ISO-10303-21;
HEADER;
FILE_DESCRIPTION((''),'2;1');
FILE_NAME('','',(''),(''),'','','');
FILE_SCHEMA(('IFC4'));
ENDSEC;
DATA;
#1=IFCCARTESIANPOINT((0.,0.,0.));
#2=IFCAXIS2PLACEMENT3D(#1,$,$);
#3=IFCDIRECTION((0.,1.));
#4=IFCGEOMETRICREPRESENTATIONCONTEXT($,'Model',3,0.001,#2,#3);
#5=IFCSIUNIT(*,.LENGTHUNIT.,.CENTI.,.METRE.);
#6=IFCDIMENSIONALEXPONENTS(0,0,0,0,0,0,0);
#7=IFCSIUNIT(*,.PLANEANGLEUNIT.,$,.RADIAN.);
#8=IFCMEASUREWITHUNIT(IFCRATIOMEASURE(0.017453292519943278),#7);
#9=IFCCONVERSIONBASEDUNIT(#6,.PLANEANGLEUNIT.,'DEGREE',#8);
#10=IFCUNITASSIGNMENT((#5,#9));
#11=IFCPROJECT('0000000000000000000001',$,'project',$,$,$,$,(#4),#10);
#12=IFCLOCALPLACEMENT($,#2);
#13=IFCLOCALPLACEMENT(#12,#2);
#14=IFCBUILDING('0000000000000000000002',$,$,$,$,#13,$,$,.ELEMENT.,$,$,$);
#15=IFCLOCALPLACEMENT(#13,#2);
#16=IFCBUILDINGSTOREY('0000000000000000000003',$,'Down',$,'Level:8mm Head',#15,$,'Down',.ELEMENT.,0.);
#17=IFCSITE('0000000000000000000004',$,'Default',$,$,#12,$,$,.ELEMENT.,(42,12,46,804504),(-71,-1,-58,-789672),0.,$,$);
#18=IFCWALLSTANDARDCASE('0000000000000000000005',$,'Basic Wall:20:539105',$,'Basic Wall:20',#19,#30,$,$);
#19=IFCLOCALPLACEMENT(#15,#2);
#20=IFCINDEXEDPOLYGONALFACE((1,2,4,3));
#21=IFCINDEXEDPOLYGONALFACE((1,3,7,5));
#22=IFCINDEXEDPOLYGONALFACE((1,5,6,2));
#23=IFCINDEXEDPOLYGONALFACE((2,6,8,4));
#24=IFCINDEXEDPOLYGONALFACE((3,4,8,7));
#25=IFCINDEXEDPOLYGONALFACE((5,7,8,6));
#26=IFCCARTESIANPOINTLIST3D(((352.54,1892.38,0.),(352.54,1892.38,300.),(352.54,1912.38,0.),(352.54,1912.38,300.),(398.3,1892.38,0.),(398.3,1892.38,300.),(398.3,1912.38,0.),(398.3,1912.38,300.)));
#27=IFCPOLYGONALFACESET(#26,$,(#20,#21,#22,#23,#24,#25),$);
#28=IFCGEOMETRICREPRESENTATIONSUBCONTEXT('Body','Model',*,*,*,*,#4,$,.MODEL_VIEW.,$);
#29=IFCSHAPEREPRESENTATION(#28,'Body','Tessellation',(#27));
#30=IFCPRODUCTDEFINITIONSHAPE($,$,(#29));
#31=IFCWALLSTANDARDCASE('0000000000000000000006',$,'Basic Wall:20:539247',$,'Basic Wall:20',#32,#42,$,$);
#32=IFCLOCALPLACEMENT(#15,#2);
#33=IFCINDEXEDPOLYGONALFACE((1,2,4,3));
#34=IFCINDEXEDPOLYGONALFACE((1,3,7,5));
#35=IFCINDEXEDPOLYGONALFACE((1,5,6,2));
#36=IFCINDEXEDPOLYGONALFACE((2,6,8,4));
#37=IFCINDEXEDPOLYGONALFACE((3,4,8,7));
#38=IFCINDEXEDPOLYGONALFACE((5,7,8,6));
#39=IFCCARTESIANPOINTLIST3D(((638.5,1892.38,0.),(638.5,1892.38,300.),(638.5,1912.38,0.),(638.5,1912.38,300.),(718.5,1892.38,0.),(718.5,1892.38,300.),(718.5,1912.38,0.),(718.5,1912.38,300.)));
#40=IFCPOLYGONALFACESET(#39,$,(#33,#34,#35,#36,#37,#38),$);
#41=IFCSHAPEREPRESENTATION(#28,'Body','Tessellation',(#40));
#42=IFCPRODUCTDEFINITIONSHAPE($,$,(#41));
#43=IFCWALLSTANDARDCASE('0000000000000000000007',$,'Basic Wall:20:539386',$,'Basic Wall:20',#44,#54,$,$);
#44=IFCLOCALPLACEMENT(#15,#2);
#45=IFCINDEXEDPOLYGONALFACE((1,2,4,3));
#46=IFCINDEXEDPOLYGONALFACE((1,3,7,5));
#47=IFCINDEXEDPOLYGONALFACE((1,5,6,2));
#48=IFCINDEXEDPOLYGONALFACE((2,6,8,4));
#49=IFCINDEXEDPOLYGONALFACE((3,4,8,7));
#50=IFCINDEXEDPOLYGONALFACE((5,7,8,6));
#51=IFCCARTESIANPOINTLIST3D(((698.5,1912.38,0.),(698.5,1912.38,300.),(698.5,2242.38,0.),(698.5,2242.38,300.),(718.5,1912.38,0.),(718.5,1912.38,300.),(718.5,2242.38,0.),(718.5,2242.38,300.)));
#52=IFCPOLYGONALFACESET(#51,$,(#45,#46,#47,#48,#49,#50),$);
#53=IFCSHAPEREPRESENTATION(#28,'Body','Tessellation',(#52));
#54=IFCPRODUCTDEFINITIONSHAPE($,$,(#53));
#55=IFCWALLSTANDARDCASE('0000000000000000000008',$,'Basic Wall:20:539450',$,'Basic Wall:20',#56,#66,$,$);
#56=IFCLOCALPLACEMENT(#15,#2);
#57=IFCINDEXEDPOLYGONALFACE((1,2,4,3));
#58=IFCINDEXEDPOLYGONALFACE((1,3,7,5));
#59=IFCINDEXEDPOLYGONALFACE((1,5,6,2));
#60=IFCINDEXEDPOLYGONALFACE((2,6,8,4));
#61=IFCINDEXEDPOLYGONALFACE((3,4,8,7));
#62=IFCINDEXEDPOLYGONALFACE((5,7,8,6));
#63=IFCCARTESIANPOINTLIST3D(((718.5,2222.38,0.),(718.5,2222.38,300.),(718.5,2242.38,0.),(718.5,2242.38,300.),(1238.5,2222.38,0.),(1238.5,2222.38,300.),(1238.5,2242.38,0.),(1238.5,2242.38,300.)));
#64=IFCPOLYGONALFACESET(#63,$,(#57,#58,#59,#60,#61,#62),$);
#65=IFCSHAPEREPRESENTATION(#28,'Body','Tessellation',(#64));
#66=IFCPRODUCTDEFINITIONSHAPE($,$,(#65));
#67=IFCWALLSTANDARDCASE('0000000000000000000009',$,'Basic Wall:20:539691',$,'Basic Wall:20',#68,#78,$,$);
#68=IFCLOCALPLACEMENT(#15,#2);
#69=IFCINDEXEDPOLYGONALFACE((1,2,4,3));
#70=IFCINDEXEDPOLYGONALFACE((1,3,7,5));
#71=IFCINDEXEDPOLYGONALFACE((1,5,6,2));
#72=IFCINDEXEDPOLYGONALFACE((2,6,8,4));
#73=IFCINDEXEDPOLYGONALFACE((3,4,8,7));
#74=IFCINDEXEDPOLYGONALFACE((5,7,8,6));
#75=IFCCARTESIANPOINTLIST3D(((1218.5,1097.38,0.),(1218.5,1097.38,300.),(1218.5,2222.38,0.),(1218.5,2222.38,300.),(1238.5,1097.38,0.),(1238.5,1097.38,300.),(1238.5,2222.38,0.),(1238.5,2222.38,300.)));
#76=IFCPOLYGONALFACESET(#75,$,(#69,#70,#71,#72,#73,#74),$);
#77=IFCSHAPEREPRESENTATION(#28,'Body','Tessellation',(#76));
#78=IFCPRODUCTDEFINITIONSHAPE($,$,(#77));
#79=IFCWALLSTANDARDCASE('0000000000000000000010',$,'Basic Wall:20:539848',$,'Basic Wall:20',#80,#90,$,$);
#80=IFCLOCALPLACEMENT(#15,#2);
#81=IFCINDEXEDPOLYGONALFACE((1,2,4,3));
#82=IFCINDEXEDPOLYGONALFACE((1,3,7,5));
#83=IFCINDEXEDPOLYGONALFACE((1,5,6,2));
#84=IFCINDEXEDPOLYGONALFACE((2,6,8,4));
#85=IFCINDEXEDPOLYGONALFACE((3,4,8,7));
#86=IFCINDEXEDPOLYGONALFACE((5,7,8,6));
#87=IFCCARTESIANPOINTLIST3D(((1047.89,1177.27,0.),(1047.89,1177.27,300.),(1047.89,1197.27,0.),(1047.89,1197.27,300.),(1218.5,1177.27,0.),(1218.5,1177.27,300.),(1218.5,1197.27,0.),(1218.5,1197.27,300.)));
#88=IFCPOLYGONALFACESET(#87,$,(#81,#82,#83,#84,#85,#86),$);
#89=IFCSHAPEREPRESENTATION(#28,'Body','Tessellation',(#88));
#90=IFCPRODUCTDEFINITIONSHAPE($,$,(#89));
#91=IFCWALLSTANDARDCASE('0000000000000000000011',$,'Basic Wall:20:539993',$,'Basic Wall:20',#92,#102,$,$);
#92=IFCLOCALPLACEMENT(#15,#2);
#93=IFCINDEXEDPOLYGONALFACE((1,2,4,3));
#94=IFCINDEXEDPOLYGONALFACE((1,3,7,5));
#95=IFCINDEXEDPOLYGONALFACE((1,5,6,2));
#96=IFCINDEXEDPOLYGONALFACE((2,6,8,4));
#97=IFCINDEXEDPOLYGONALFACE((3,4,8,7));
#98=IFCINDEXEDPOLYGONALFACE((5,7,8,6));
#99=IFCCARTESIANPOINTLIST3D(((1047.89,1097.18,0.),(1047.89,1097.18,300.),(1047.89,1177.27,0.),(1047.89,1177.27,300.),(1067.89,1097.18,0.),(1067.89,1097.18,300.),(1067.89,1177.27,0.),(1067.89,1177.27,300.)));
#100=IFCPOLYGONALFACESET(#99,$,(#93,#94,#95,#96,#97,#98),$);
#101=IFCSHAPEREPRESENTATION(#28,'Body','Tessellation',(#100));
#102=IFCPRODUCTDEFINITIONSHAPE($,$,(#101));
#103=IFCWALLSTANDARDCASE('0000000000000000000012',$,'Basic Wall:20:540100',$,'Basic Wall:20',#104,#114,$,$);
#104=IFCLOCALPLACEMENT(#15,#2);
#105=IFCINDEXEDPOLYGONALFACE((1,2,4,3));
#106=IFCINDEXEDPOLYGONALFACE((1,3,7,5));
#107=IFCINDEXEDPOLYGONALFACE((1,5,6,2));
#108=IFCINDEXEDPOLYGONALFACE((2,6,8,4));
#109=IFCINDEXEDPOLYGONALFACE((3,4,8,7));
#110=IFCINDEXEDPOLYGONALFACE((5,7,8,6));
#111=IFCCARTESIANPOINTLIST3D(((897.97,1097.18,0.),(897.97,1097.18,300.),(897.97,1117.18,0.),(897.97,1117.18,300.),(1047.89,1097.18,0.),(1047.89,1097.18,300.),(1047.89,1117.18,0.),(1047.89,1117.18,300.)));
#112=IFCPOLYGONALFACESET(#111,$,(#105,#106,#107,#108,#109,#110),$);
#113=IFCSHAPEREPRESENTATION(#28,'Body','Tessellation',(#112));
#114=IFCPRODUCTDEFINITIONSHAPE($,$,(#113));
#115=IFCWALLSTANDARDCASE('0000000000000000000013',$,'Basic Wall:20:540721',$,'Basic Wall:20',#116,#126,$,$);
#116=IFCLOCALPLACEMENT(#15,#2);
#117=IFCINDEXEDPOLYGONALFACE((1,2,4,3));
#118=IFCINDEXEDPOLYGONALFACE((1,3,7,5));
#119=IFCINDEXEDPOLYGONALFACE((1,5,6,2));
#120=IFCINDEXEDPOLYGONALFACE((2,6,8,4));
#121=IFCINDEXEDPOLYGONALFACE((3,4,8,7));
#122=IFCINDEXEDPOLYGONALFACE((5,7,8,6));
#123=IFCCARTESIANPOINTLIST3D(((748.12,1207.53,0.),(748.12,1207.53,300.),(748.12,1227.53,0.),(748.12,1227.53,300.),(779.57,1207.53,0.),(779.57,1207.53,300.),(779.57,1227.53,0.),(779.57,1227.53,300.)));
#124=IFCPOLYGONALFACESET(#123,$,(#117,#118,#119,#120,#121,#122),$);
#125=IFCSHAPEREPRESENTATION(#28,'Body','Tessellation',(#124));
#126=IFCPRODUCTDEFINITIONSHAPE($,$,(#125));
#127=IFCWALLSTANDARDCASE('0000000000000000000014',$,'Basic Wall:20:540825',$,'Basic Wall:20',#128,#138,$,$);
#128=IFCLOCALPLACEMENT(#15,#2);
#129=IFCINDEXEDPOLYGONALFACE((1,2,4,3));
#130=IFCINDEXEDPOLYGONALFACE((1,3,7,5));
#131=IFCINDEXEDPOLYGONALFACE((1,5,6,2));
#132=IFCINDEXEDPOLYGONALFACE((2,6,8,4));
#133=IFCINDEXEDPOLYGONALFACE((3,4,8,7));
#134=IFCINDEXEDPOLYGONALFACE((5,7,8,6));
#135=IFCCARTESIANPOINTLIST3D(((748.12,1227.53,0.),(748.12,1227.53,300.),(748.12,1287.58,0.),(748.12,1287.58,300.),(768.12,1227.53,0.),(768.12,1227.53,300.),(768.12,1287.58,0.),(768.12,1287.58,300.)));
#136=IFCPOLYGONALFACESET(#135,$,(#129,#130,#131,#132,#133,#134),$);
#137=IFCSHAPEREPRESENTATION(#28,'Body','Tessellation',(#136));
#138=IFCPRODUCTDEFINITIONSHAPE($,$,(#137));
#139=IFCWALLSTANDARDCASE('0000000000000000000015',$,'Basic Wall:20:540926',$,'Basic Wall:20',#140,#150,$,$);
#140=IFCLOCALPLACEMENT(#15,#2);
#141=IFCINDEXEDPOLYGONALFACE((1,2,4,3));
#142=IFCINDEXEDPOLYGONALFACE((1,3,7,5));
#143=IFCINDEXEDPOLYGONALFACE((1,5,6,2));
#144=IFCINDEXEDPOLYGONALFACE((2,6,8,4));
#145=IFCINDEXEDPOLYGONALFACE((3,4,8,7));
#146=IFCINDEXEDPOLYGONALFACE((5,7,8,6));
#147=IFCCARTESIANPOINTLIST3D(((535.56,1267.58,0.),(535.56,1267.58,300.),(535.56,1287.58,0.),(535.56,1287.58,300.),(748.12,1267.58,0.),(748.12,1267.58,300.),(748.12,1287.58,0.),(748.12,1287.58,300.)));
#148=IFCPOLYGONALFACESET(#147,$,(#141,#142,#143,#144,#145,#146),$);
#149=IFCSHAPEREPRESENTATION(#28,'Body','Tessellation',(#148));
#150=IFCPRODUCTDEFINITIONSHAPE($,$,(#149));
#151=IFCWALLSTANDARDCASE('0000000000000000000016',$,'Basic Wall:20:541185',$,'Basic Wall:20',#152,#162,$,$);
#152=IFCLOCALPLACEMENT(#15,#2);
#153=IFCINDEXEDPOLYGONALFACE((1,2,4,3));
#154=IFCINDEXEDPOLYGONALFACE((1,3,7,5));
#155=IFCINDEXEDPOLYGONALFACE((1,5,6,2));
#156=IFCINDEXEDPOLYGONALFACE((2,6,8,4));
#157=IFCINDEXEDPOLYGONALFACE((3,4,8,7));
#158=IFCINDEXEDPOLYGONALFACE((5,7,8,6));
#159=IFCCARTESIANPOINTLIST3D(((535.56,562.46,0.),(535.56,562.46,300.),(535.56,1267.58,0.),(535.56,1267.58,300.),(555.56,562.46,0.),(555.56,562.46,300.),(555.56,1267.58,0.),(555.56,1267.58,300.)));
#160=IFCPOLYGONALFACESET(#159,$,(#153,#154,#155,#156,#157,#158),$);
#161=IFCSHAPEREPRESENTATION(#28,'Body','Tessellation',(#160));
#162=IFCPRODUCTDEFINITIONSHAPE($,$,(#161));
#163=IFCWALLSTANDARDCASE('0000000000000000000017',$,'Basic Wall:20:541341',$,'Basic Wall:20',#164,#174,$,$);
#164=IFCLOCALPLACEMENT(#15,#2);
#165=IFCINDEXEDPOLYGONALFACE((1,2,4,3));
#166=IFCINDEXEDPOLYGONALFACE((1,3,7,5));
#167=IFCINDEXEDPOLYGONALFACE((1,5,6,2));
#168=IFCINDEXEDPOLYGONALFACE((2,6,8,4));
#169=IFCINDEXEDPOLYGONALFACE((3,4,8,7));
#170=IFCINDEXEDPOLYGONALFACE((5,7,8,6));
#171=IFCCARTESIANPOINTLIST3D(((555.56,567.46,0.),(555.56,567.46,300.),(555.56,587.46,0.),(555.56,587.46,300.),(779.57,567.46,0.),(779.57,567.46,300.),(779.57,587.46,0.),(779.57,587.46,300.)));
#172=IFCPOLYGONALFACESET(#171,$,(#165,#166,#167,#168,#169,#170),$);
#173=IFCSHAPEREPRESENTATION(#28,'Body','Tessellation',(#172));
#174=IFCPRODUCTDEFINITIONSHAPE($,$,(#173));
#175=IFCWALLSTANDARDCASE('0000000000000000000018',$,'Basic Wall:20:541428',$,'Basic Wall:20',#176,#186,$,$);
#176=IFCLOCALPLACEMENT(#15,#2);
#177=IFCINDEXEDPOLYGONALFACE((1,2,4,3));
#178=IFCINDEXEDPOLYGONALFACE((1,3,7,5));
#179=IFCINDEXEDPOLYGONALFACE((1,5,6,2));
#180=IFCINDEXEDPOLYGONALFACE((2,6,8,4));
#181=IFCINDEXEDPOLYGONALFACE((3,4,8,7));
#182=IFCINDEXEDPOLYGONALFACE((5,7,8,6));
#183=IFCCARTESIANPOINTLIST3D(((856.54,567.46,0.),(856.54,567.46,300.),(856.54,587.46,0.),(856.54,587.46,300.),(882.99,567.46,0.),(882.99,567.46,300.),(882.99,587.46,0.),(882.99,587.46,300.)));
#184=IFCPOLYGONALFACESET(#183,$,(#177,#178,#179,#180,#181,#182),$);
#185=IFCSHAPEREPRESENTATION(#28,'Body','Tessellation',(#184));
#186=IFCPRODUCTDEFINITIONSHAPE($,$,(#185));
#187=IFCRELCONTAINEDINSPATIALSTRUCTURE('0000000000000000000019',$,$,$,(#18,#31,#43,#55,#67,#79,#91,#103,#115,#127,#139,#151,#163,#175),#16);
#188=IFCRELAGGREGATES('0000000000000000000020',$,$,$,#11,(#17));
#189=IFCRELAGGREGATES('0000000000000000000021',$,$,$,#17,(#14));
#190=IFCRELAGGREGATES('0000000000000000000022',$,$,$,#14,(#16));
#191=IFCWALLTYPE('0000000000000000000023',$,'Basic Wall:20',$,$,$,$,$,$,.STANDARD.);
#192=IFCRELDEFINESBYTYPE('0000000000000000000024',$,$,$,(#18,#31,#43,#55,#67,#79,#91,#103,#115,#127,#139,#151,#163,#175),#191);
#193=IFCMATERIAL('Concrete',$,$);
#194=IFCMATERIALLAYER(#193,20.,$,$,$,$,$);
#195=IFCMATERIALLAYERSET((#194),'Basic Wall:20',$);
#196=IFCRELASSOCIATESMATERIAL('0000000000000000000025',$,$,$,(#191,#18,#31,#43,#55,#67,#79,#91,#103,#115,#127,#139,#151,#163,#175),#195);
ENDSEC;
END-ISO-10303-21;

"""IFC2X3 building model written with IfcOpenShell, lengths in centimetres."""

from ifc_helpers import new_model, entity, si_unit, converted_unit, direction, frame, frame_2d, origin, place, context, subcontext, project, spatial, rectangle, extrude, material, layer, layer_set, layer_usage, type_object, element, save


model = new_model("IFC2X3")

# Units and contexts
model_context = context("Model", 3, precision=0.001, world=origin(), true_north=direction((0.0, 1.0)))
body_context = subcontext(model_context, "Body", "Model", "MODEL_VIEW")
ifc_project = project(units=[si_unit("LENGTHUNIT", "METRE", prefix="CENTI"), converted_unit("PLANEANGLEUNIT", "DEGREE", entity("IfcRatioMeasure", 0.017453292519943278), si_unit("PLANEANGLEUNIT", "RADIAN"), dimensions=[0, 0, 0, 0, 0, 0, 0])], contexts=[model_context])

# Site, building, storey
site_placement = place(None, origin())
site = spatial("IfcSite", under=ifc_project, at=site_placement, Name="Default", CompositionType="ELEMENT", RefLatitude=(42, 12, 46, 804504), RefLongitude=(-71, -1, -58, -789672), RefElevation=0.0)
building_placement = place(site_placement, origin())
building = spatial("IfcBuilding", under=site, at=building_placement, CompositionType="ELEMENT")
storey_placement = place(building_placement, origin())
storey = spatial("IfcBuildingStorey", under=building, at=storey_placement, Name="Down", ObjectType="Level:8mm Head", LongName="Down", CompositionType="ELEMENT", Elevation=0.0)

# Walls
ifc_material = material(Name="Concrete")
ifc_layer_1 = layer(ifc_material, 20.0)
ifc_layer_set_1 = layer_set([ifc_layer_1], Name="Basic Wall:20")
ifc_layer_usage_1 = layer_usage(ifc_layer_set_1, "AXIS2", "NEGATIVE", 10.0)
wall_type_1 = type_object("IfcWallType", Name="Basic Wall:20", PredefinedType="STANDARD", material=ifc_layer_set_1)
wall_1_placement = place(storey_placement, frame((352.54, 1902.38, 0.0)))
element("IfcWallStandardCase", 1, at=wall_1_placement, inside=storey, type_object=wall_type_1, material=ifc_layer_usage_1, Name="Basic Wall:20:539105", ObjectType="Basic Wall:20", context=body_context, shape_type="SweptSolid", body=[
    extrude(rectangle(XDim=45.77, YDim=20.0, at=frame_2d((22.88, 0.0), x_axis=(-1.0, 0.0))), origin(), (0.0, 0.0, 1.0), 300.0),
])
ifc_layer_usage_2 = layer_usage(ifc_layer_set_1, "AXIS2", "NEGATIVE", 10.0)
wall_2_placement = place(storey_placement, frame((638.5, 1902.38, 0.0)))
element("IfcWallStandardCase", 2, at=wall_2_placement, inside=storey, type_object=wall_type_1, material=ifc_layer_usage_2, Name="Basic Wall:20:539247", ObjectType="Basic Wall:20", context=body_context, shape_type="SweptSolid", body=[
    extrude(rectangle(XDim=80.0, YDim=20.0, at=frame_2d((40.0, 0.0), x_axis=(-1.0, 0.0))), origin(), (0.0, 0.0, 1.0), 300.0),
])
ifc_layer_usage_3 = layer_usage(ifc_layer_set_1, "AXIS2", "POSITIVE", -10.0)
wall_3_placement = place(storey_placement, frame((708.5, 1912.38, 0.0), z_axis=(0.0, 0.0, 1.0), x_axis=(0.0, 1.0, 0.0)))
element("IfcWallStandardCase", 3, at=wall_3_placement, inside=storey, type_object=wall_type_1, material=ifc_layer_usage_3, Name="Basic Wall:20:539386", ObjectType="Basic Wall:20", context=body_context, shape_type="SweptSolid", body=[
    extrude(rectangle(XDim=330.0, YDim=20.0, at=frame_2d((165.0, 0.0), x_axis=(-1.0, 0.0))), origin(), (0.0, 0.0, 1.0), 300.0),
])
ifc_layer_usage_4 = layer_usage(ifc_layer_set_1, "AXIS2", "NEGATIVE", 10.0)
wall_4_placement = place(storey_placement, frame((718.5, 2232.38, 0.0)))
element("IfcWallStandardCase", 4, at=wall_4_placement, inside=storey, type_object=wall_type_1, material=ifc_layer_usage_4, Name="Basic Wall:20:539450", ObjectType="Basic Wall:20", context=body_context, shape_type="SweptSolid", body=[
    extrude(rectangle(XDim=520.0, YDim=20.0, at=frame_2d((260.0, 0.0), x_axis=(-1.0, 0.0))), origin(), (0.0, 0.0, 1.0), 300.0),
])
ifc_layer_usage_5 = layer_usage(ifc_layer_set_1, "AXIS2", "NEGATIVE", 10.0)
wall_5_placement = place(storey_placement, frame((1228.5, 2222.38, 0.0), z_axis=(0.0, 0.0, 1.0), x_axis=(0.0, -1.0, 0.0)))
element("IfcWallStandardCase", 5, at=wall_5_placement, inside=storey, type_object=wall_type_1, material=ifc_layer_usage_5, Name="Basic Wall:20:539691", ObjectType="Basic Wall:20", context=body_context, shape_type="SweptSolid", body=[
    extrude(rectangle(XDim=1125.0, YDim=20.0, at=frame_2d((562.5, 0.0), x_axis=(-1.0, 0.0))), origin(), (0.0, 0.0, 1.0), 300.0),
])
ifc_layer_usage_6 = layer_usage(ifc_layer_set_1, "AXIS2", "NEGATIVE", 10.0)
wall_6_placement = place(storey_placement, frame((1047.89, 1187.27, 0.0)))
element("IfcWallStandardCase", 6, at=wall_6_placement, inside=storey, type_object=wall_type_1, material=ifc_layer_usage_6, Name="Basic Wall:20:539848", ObjectType="Basic Wall:20", context=body_context, shape_type="SweptSolid", body=[
    extrude(rectangle(XDim=170.61, YDim=20.0, at=frame_2d((85.31, 0.0), x_axis=(-1.0, 0.0))), origin(), (0.0, 0.0, 1.0), 300.0),
])
ifc_layer_usage_7 = layer_usage(ifc_layer_set_1, "AXIS2", "POSITIVE", -10.0)
wall_7_placement = place(storey_placement, frame((1057.89, 1177.27, 0.0), z_axis=(0.0, 0.0, 1.0), x_axis=(0.0, -1.0, 0.0)))
element("IfcWallStandardCase", 7, at=wall_7_placement, inside=storey, type_object=wall_type_1, material=ifc_layer_usage_7, Name="Basic Wall:20:539993", ObjectType="Basic Wall:20", context=body_context, shape_type="SweptSolid", body=[
    extrude(rectangle(XDim=80.08, YDim=20.0, at=frame_2d((40.04, 0.0), x_axis=(-1.0, 0.0))), origin(), (0.0, 0.0, 1.0), 300.0),
])
ifc_layer_usage_8 = layer_usage(ifc_layer_set_1, "AXIS2", "NEGATIVE", 10.0)
wall_8_placement = place(storey_placement, frame((1047.89, 1107.18, 0.0), z_axis=(0.0, 0.0, 1.0), x_axis=(-1.0, 0.0, 0.0)))
element("IfcWallStandardCase", 8, at=wall_8_placement, inside=storey, type_object=wall_type_1, material=ifc_layer_usage_8, Name="Basic Wall:20:540100", ObjectType="Basic Wall:20", context=body_context, shape_type="SweptSolid", body=[
    extrude(rectangle(XDim=149.91, YDim=20.0, at=frame_2d((74.96, 0.0), x_axis=(-1.0, 0.0))), origin(), (0.0, 0.0, 1.0), 300.0),
])
ifc_layer_usage_9 = layer_usage(ifc_layer_set_1, "AXIS2", "POSITIVE", -10.0)
wall_9_placement = place(storey_placement, frame((779.57, 1217.53, 0.0), z_axis=(0.0, 0.0, 1.0), x_axis=(-1.0, 0.0, 0.0)))
element("IfcWallStandardCase", 9, at=wall_9_placement, inside=storey, type_object=wall_type_1, material=ifc_layer_usage_9, Name="Basic Wall:20:540721", ObjectType="Basic Wall:20", context=body_context, shape_type="SweptSolid", body=[
    extrude(rectangle(XDim=31.45, YDim=20.0, at=frame_2d((15.73, 0.0), x_axis=(-1.0, 0.0))), origin(), (0.0, 0.0, 1.0), 300.0),
])
ifc_layer_usage_10 = layer_usage(ifc_layer_set_1, "AXIS2", "NEGATIVE", 10.0)
wall_10_placement = place(storey_placement, frame((758.12, 1227.53, 0.0), z_axis=(0.0, 0.0, 1.0), x_axis=(0.0, 1.0, 0.0)))
element("IfcWallStandardCase", 10, at=wall_10_placement, inside=storey, type_object=wall_type_1, material=ifc_layer_usage_10, Name="Basic Wall:20:540825", ObjectType="Basic Wall:20", context=body_context, shape_type="SweptSolid", body=[
    extrude(rectangle(XDim=60.05, YDim=20.0, at=frame_2d((30.02, 0.0), x_axis=(-1.0, 0.0))), origin(), (0.0, 0.0, 1.0), 300.0),
])
ifc_layer_usage_11 = layer_usage(ifc_layer_set_1, "AXIS2", "POSITIVE", -10.0)
wall_11_placement = place(storey_placement, frame((748.12, 1277.58, 0.0), z_axis=(0.0, 0.0, 1.0), x_axis=(-1.0, 0.0, 0.0)))
element("IfcWallStandardCase", 11, at=wall_11_placement, inside=storey, type_object=wall_type_1, material=ifc_layer_usage_11, Name="Basic Wall:20:540926", ObjectType="Basic Wall:20", context=body_context, shape_type="SweptSolid", body=[
    extrude(rectangle(XDim=212.56, YDim=20.0, at=frame_2d((106.28, 0.0), x_axis=(-1.0, 0.0))), origin(), (0.0, 0.0, 1.0), 300.0),
])
ifc_layer_usage_12 = layer_usage(ifc_layer_set_1, "AXIS2", "POSITIVE", -10.0)
wall_12_placement = place(storey_placement, frame((545.56, 1267.58, 0.0), z_axis=(0.0, 0.0, 1.0), x_axis=(0.0, -1.0, 0.0)))
element("IfcWallStandardCase", 12, at=wall_12_placement, inside=storey, type_object=wall_type_1, material=ifc_layer_usage_12, Name="Basic Wall:20:541185", ObjectType="Basic Wall:20", context=body_context, shape_type="SweptSolid", body=[
    extrude(rectangle(XDim=705.12, YDim=20.0, at=frame_2d((352.56, 0.0), x_axis=(-1.0, 0.0))), origin(), (0.0, 0.0, 1.0), 300.0),
])
ifc_layer_usage_13 = layer_usage(ifc_layer_set_1, "AXIS2", "POSITIVE", -10.0)
wall_13_placement = place(storey_placement, frame((555.56, 577.46, 0.0)))
element("IfcWallStandardCase", 13, at=wall_13_placement, inside=storey, type_object=wall_type_1, material=ifc_layer_usage_13, Name="Basic Wall:20:541341", ObjectType="Basic Wall:20", context=body_context, shape_type="SweptSolid", body=[
    extrude(rectangle(XDim=224.01, YDim=20.0, at=frame_2d((112.01, 0.0), x_axis=(-1.0, 0.0))), origin(), (0.0, 0.0, 1.0), 300.0),
])
ifc_layer_usage_14 = layer_usage(ifc_layer_set_1, "AXIS2", "POSITIVE", -10.0)
wall_14_placement = place(storey_placement, frame((856.54, 577.46, 0.0)))
element("IfcWallStandardCase", 14, at=wall_14_placement, inside=storey, type_object=wall_type_1, material=ifc_layer_usage_14, Name="Basic Wall:20:541428", ObjectType="Basic Wall:20", context=body_context, shape_type="SweptSolid", body=[
    extrude(rectangle(XDim=26.45, YDim=20.0, at=frame_2d((13.23, 0.0), x_axis=(-1.0, 0.0))), origin(), (0.0, 0.0, 1.0), 300.0),
])

save(model, "model.ifc")
